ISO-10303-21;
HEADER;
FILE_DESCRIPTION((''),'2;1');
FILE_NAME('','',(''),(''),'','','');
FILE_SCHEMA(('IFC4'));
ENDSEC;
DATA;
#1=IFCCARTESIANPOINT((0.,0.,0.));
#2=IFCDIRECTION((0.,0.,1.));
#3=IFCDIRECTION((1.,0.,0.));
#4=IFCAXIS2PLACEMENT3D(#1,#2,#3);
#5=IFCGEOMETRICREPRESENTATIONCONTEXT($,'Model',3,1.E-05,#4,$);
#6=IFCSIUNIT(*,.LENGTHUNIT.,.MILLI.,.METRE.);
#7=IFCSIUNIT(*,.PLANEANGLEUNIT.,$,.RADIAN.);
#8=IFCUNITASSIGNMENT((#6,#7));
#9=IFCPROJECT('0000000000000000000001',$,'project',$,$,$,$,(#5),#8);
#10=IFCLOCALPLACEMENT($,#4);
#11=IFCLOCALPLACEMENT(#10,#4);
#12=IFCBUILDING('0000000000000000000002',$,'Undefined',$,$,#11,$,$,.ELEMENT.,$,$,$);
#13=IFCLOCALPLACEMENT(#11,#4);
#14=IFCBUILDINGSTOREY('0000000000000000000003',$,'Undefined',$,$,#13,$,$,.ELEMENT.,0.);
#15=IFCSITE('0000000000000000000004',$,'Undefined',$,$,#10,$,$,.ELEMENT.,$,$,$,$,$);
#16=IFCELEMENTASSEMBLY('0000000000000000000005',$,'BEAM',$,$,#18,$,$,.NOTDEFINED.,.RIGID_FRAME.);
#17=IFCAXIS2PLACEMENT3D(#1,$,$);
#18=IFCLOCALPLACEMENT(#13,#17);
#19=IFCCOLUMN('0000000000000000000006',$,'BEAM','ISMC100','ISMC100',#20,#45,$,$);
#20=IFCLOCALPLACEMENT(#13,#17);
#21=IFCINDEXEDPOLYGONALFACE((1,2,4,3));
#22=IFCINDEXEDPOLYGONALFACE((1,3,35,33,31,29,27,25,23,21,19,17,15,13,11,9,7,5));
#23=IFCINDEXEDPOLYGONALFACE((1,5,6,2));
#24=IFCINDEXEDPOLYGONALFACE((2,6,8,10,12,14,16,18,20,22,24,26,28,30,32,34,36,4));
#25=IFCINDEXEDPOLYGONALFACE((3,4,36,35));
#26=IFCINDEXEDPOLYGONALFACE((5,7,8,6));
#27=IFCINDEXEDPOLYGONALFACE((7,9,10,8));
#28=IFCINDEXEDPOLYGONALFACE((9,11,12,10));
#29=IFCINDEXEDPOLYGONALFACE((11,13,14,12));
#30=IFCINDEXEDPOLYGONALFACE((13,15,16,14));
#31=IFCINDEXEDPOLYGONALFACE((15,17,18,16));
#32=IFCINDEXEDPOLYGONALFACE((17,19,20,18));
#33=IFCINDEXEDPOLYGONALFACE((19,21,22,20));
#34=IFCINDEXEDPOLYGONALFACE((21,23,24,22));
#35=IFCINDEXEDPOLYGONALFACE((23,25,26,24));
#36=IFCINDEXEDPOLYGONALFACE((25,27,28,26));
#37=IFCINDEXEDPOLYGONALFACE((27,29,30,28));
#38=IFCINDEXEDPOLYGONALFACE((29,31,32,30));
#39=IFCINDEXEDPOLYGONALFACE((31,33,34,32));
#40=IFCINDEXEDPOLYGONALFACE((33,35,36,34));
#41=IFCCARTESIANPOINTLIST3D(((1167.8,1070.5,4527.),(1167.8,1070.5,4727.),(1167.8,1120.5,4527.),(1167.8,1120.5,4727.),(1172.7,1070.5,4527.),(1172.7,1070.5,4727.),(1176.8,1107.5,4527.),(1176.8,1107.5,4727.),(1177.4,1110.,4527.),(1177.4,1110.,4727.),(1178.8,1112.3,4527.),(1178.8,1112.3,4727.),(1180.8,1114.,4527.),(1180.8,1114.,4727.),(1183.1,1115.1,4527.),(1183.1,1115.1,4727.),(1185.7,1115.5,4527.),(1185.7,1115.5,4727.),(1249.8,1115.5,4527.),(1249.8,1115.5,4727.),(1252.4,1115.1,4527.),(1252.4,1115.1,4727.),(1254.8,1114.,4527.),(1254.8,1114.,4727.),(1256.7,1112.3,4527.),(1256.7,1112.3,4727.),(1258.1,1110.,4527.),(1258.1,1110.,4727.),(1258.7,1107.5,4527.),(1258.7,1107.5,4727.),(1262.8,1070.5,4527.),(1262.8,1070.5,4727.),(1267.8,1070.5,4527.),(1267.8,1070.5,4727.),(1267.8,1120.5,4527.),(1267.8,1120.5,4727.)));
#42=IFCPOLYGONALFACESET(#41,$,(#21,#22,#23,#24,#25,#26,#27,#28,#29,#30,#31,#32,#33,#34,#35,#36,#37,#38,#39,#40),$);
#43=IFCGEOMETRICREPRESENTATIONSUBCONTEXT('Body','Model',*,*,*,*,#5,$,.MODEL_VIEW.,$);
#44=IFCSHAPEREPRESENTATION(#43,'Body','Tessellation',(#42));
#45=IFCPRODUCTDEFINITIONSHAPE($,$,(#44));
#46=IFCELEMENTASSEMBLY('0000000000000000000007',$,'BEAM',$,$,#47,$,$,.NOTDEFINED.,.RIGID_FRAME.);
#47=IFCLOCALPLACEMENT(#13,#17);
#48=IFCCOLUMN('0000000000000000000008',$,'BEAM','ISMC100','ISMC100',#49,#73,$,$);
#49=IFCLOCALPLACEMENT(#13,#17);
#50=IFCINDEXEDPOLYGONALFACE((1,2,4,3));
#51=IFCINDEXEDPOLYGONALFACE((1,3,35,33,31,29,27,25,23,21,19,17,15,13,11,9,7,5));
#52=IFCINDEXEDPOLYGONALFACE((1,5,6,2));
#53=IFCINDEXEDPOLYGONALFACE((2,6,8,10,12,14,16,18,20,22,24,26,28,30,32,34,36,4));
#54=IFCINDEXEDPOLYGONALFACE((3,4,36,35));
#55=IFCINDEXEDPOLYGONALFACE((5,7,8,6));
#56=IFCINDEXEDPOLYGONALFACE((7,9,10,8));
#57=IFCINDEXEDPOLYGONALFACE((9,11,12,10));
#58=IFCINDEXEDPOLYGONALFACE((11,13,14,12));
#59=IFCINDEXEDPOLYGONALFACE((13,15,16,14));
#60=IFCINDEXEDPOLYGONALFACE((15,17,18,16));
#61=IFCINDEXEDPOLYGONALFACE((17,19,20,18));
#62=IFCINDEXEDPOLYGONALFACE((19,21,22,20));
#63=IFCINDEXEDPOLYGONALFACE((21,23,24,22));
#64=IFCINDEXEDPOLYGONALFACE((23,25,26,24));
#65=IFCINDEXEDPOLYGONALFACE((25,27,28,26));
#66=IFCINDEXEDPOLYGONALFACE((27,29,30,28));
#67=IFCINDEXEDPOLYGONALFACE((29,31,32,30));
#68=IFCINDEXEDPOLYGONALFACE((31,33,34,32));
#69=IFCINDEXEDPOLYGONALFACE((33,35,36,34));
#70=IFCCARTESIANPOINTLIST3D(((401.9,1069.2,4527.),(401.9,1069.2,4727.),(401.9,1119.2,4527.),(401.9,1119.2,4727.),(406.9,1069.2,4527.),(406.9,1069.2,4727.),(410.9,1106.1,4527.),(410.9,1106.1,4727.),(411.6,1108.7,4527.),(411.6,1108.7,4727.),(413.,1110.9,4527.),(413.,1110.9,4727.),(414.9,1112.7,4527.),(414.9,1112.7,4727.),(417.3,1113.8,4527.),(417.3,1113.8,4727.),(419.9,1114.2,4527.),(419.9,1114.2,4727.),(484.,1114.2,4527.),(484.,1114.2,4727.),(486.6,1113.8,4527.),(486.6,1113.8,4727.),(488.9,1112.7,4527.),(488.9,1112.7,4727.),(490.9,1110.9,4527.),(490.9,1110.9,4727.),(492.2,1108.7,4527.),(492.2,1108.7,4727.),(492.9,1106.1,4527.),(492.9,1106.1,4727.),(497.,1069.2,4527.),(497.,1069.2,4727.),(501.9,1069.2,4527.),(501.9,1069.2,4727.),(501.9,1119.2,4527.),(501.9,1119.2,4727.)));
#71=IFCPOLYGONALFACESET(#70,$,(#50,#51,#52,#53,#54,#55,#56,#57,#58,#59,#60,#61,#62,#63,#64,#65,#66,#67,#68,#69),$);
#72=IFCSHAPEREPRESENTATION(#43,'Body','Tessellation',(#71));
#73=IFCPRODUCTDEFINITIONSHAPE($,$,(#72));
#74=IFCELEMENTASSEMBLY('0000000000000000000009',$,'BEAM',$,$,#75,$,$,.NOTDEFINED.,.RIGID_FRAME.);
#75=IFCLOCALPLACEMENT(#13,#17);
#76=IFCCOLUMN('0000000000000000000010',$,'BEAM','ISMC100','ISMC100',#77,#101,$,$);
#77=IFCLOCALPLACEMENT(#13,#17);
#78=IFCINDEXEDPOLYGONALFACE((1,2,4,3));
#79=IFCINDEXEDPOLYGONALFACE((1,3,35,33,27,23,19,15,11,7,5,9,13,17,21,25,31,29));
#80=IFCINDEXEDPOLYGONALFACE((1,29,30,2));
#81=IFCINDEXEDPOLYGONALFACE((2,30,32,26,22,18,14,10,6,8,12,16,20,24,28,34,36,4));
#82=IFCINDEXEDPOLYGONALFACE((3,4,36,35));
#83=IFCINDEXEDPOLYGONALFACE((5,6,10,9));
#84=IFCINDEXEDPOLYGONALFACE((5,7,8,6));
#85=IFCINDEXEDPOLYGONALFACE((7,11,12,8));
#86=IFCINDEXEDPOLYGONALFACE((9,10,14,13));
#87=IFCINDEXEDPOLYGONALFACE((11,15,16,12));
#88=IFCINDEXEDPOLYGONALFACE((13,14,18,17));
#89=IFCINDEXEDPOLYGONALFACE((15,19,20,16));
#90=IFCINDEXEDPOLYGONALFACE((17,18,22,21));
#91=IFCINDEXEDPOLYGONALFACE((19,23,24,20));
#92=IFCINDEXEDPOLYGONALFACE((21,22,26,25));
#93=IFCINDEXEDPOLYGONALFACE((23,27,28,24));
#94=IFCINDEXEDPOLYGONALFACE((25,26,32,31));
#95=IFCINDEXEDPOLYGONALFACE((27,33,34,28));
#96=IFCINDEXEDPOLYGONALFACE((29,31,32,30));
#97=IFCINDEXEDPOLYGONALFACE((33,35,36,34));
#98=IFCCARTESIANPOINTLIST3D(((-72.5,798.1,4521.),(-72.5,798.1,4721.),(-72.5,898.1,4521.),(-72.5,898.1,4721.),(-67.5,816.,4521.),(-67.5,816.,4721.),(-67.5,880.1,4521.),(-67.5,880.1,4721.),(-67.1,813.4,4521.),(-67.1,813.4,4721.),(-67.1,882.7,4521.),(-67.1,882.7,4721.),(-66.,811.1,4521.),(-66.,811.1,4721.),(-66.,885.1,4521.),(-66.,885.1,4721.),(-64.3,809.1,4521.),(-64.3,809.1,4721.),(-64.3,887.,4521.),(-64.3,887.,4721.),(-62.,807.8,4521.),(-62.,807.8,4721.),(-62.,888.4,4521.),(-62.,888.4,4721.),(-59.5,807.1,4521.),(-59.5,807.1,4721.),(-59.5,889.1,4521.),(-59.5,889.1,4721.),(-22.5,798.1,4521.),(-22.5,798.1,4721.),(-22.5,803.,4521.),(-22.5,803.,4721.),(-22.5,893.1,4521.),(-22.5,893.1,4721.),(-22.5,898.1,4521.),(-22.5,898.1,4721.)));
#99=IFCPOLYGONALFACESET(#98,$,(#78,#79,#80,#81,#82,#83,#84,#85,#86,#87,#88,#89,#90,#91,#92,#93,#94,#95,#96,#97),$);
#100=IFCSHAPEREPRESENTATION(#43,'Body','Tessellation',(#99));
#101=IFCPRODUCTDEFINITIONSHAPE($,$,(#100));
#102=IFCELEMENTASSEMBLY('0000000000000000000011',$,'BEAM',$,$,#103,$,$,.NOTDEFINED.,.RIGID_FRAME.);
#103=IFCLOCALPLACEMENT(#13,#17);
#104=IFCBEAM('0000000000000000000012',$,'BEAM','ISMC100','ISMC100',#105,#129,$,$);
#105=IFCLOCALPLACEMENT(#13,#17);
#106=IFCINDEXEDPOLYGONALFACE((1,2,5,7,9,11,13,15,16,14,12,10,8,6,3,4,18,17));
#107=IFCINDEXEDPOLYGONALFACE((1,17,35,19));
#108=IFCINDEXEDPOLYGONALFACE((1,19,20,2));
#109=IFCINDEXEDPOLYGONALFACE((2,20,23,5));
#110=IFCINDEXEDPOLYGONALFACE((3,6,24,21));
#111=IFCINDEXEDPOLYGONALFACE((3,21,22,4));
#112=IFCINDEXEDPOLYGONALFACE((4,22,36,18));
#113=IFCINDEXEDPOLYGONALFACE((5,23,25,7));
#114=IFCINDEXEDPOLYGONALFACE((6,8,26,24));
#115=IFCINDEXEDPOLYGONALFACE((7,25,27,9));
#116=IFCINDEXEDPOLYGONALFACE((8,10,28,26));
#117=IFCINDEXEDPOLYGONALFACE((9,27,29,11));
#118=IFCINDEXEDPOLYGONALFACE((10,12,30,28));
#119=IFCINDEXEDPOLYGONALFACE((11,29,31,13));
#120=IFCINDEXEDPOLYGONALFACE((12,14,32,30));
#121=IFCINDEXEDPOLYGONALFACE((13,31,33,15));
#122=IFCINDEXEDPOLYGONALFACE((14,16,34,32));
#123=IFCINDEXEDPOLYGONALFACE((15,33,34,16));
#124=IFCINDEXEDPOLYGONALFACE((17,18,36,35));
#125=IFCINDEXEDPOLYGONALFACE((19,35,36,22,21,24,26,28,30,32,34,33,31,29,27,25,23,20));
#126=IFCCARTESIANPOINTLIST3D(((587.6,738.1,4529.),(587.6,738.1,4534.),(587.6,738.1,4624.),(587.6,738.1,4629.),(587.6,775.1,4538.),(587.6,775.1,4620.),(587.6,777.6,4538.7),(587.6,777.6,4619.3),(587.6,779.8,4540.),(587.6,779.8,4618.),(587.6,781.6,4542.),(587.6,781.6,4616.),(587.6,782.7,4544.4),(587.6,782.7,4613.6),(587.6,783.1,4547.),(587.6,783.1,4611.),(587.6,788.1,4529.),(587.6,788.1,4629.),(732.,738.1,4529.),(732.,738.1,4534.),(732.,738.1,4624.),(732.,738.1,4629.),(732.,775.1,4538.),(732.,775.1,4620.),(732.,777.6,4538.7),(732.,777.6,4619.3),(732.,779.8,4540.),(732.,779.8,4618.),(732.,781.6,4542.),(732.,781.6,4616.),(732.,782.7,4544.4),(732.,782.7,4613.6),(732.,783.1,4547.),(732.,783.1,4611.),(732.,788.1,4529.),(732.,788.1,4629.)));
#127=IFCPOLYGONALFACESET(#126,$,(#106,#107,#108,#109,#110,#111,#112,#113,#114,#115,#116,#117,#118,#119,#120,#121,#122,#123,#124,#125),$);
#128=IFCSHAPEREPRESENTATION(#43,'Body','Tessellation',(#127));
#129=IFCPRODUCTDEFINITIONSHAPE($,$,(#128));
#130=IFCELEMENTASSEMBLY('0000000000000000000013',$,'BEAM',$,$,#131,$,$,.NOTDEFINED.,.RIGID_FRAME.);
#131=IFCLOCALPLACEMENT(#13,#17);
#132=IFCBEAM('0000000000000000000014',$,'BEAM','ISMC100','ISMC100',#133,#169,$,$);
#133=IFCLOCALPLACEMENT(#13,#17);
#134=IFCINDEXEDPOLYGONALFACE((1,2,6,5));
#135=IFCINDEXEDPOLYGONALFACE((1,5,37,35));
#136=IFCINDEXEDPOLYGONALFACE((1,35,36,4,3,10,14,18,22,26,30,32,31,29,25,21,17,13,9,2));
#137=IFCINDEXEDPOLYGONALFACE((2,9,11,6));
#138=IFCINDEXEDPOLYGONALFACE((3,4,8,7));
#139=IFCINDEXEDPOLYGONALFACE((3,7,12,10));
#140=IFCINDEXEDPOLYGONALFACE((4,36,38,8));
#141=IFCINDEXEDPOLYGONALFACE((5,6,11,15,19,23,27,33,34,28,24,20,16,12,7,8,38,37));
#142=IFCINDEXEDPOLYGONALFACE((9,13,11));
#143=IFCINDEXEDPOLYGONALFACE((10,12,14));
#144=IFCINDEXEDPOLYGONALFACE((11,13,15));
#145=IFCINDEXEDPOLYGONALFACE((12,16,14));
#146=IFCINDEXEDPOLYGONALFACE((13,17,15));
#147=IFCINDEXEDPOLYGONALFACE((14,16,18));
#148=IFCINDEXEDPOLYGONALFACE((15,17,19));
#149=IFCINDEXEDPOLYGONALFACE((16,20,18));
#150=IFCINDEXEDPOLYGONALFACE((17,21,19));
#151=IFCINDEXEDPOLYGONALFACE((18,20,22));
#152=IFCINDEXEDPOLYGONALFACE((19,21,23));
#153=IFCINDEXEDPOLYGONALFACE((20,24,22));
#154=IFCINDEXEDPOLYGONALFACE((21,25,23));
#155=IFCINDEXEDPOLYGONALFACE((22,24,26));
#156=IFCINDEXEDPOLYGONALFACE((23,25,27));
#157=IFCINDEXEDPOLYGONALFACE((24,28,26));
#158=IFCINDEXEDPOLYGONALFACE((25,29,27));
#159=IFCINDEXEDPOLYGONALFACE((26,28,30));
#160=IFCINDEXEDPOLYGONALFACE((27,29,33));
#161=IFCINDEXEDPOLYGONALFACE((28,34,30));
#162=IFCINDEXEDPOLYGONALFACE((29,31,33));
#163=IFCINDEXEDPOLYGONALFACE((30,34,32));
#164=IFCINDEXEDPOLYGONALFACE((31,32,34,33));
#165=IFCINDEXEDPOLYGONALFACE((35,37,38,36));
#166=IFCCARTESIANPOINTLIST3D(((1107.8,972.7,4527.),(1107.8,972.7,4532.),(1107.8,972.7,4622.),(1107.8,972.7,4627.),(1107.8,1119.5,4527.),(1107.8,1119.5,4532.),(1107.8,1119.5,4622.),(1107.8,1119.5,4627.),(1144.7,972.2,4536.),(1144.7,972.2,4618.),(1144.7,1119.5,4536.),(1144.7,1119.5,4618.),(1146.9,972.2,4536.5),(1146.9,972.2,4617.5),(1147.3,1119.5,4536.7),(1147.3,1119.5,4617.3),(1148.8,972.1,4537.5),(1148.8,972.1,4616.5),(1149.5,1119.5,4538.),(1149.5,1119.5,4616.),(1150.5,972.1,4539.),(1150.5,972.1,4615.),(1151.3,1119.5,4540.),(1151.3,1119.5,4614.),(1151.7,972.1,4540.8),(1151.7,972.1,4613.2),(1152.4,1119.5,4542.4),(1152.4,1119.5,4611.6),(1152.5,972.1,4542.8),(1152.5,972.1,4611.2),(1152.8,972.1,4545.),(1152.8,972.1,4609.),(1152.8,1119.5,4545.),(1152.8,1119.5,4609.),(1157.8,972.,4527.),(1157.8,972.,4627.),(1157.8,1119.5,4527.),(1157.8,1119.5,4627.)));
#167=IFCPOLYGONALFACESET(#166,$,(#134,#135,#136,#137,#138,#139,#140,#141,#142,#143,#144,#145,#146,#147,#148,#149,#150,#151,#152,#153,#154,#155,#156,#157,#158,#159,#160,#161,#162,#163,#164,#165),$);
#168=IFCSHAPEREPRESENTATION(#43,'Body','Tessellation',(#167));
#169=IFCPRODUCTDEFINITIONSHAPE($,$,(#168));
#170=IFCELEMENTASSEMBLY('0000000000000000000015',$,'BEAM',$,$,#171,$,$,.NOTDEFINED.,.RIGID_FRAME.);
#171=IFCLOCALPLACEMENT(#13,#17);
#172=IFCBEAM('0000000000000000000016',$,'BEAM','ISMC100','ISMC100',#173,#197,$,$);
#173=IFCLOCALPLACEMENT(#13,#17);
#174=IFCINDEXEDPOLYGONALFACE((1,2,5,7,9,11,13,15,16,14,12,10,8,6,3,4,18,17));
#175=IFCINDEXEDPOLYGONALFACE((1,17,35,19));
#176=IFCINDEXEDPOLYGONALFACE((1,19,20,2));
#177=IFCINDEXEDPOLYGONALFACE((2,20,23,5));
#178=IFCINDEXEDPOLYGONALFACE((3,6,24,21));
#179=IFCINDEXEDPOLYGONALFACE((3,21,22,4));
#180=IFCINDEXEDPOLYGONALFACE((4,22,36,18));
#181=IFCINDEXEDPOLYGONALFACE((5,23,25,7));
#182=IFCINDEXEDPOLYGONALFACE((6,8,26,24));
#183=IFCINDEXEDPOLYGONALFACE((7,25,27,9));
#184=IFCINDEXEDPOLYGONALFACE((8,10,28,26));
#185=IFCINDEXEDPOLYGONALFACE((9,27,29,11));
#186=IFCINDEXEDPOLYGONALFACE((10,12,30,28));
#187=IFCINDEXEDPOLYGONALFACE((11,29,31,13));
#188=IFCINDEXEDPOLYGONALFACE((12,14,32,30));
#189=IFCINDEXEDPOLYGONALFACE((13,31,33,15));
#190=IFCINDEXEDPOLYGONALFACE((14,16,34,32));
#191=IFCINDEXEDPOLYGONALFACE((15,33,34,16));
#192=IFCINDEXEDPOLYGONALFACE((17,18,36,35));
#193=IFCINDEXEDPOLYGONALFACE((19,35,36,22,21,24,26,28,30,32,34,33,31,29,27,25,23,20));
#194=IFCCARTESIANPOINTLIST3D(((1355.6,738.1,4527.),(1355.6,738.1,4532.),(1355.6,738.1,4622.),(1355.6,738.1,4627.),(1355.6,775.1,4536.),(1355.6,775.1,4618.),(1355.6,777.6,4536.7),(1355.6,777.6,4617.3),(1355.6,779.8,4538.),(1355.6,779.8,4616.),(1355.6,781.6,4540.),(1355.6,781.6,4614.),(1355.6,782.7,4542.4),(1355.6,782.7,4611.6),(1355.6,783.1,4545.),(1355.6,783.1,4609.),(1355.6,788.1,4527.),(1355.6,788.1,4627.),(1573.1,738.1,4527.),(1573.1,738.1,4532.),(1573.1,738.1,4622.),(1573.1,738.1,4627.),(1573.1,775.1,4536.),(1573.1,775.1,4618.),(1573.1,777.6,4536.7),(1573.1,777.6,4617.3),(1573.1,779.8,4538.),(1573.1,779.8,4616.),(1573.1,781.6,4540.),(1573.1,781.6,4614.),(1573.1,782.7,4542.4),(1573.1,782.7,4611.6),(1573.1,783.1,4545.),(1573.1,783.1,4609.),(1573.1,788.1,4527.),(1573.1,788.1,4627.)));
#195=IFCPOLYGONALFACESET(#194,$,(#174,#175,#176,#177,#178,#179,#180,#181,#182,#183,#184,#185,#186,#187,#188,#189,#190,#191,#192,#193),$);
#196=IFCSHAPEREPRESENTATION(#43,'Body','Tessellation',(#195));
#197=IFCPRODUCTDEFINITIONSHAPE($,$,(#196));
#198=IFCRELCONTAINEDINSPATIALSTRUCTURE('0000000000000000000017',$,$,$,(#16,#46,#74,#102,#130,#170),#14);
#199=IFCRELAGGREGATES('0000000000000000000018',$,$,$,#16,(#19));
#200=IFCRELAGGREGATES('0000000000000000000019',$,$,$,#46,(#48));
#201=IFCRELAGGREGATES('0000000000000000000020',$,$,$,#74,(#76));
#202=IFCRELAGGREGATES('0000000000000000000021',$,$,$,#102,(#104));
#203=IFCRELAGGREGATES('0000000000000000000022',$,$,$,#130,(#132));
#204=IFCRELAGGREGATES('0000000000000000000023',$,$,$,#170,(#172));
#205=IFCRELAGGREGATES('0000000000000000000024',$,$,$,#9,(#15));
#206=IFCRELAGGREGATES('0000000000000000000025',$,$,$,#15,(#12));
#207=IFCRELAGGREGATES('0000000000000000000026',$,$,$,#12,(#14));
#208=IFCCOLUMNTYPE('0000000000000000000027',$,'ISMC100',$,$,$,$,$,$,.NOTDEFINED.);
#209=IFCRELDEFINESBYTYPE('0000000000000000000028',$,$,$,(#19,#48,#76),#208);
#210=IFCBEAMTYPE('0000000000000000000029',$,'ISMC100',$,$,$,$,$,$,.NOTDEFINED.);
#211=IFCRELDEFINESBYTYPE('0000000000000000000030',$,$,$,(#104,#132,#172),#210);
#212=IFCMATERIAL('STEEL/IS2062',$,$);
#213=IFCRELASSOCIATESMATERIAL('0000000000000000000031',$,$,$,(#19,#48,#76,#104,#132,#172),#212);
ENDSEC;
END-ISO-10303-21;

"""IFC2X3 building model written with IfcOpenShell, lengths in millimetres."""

from ifc_helpers import new_model, si_unit, frame, origin_with_axes, origin_2d_with_axis, place, context, subcontext, project, spatial, u_section, extrude, clip, halfspace, material, type_object, element, aggregate, save


model = new_model("IFC2X3")

# Units and contexts
model_context = context("Model", 3, precision=1e-05, world=origin_with_axes())
body_context = subcontext(model_context, "Body", "Model", "MODEL_VIEW")
ifc_project = project(units=[si_unit("LENGTHUNIT", "METRE", prefix="MILLI"), si_unit("PLANEANGLEUNIT", "RADIAN")], contexts=[model_context])

# Site, building, storey
site_placement = place(None, origin_with_axes())
site = spatial("IfcSite", under=ifc_project, at=site_placement, Name="Undefined", CompositionType="ELEMENT")
building_placement = place(site_placement, origin_with_axes())
building = spatial("IfcBuilding", under=site, at=building_placement, Name="Undefined", CompositionType="ELEMENT")
storey_placement = place(building_placement, origin_with_axes())
storey = spatial("IfcBuildingStorey", under=building, at=storey_placement, Name="Undefined", CompositionType="ELEMENT", Elevation=0.0)

# Element assemblies, columns
assembly_1_placement = place(storey_placement, origin_with_axes())
assembly_1 = element("IfcElementAssembly", 1, at=assembly_1_placement, inside=storey, Name="BEAM", AssemblyPlace="NOTDEFINED", PredefinedType="RIGID_FRAME")
ifc_material = material(Name="STEEL/IS2062")
column_type = type_object("IfcColumnType", Name="ISMC100", PredefinedType="NOTDEFINED")
column_1_placement = place(assembly_1_placement, frame((1217.8, 1095.5, 4527.0), z_axis=(0.0, 0.0, 1.0), x_axis=(-1.0, 0.0, 0.0)))
column_1 = element("IfcColumn", 2, at=column_1_placement, type_object=column_type, material=ifc_material, Name="BEAM", Description="ISMC100", ObjectType="ISMC100", context=body_context, shape_type="SweptSolid", body=[
    extrude(u_section(Depth=100.0, FlangeWidth=50.0, WebThickness=5.0, FlangeThickness=7.7, FilletRadius=9.0, FlangeSlope=0.10956, at=origin_2d_with_axis()), frame((0.0, 0.0, 200.0), z_axis=(0.0, 0.0, -1.0), x_axis=(0.0, 1.0, 0.0)), (0.0, 0.0, 1.0), 200.0),
])
aggregate(assembly_1, [column_1])
assembly_2_placement = place(storey_placement, origin_with_axes())
assembly_2 = element("IfcElementAssembly", 3, at=assembly_2_placement, inside=storey, Name="BEAM", AssemblyPlace="NOTDEFINED", PredefinedType="RIGID_FRAME")
column_2_placement = place(assembly_2_placement, frame((451.9, 1094.2, 4527.0), z_axis=(0.0, 0.0, 1.0), x_axis=(-1.0, 0.0, 0.0)))
column_2 = element("IfcColumn", 4, at=column_2_placement, type_object=column_type, material=ifc_material, Name="BEAM", Description="ISMC100", ObjectType="ISMC100", context=body_context, shape_type="SweptSolid", body=[
    extrude(u_section(Depth=100.0, FlangeWidth=50.0, WebThickness=5.0, FlangeThickness=7.7, FilletRadius=9.0, FlangeSlope=0.10956, at=origin_2d_with_axis()), frame((0.0, 0.0, 200.0), z_axis=(0.0, 0.0, -1.0), x_axis=(0.0, 1.0, 0.0)), (0.0, 0.0, 1.0), 200.0),
])
aggregate(assembly_2, [column_2])
assembly_3_placement = place(storey_placement, origin_with_axes())
assembly_3 = element("IfcElementAssembly", 5, at=assembly_3_placement, inside=storey, Name="BEAM", AssemblyPlace="NOTDEFINED", PredefinedType="RIGID_FRAME")
column_3_placement = place(assembly_3_placement, frame((-47.5, 848.1, 4521.0), z_axis=(0.0, 0.0, 1.0), x_axis=(0.0, -1.0, 0.0)))
column_3 = element("IfcColumn", 6, at=column_3_placement, type_object=column_type, material=ifc_material, Name="BEAM", Description="ISMC100", ObjectType="ISMC100", context=body_context, shape_type="SweptSolid", body=[
    extrude(u_section(Depth=100.0, FlangeWidth=50.0, WebThickness=5.0, FlangeThickness=7.7, FilletRadius=9.0, FlangeSlope=0.10956, at=origin_2d_with_axis()), frame((0.0, 0.0, 200.0), z_axis=(0.0, 0.0, -1.0), x_axis=(0.0, 1.0, 0.0)), (0.0, 0.0, 1.0), 200.0),
])
aggregate(assembly_3, [column_3])

# Element assemblies, beams
assembly_4_placement = place(storey_placement, origin_with_axes())
assembly_4 = element("IfcElementAssembly", 7, at=assembly_4_placement, inside=storey, Name="BEAM", AssemblyPlace="NOTDEFINED", PredefinedType="RIGID_FRAME")
beam_type_1 = type_object("IfcBeamType", Name="ISMC100", PredefinedType="NOTDEFINED")
beam_1_placement = place(assembly_4_placement, frame((732.0, 763.1, 4579.0), z_axis=(0.0, 0.0, -1.0), x_axis=(-1.0, 0.0, 0.0)))
beam_1 = element("IfcBeam", 8, at=beam_1_placement, type_object=beam_type_1, material=ifc_material, Name="BEAM", Description="ISMC100", ObjectType="ISMC100", context=body_context, shape_type="SweptSolid", body=[
    extrude(u_section(Depth=100.0, FlangeWidth=50.0, WebThickness=5.0, FlangeThickness=7.7, FilletRadius=9.0, FlangeSlope=0.10956, at=origin_2d_with_axis()), frame((144.4, 0.0, 0.0), z_axis=(-1.0, 0.0, 0.0), x_axis=(0.0, -1.0, 0.0)), (0.0, 0.0, 1.0), 144.4),
])
aggregate(assembly_4, [beam_1])
assembly_5_placement = place(storey_placement, origin_with_axes())
assembly_5 = element("IfcElementAssembly", 9, at=assembly_5_placement, inside=storey, Name="BEAM", AssemblyPlace="NOTDEFINED", PredefinedType="RIGID_FRAME")
beam_2_placement = place(assembly_5_placement, frame((1132.8, 972.0, 4577.0), z_axis=(0.0, 0.0, -1.0), x_axis=(0.0, 1.0, 0.0)))
beam_2 = element("IfcBeam", 10, at=beam_2_placement, type_object=beam_type_1, material=ifc_material, Name="BEAM", Description="ISMC100", ObjectType="ISMC100", context=body_context, shape_type="Clipping", body=[
    clip(extrude(u_section(Depth=100.0, FlangeWidth=50.0, WebThickness=5.0, FlangeThickness=7.7, FilletRadius=9.0, FlangeSlope=0.10956, at=origin_2d_with_axis()), frame((147.5, 0.0, 0.0), z_axis=(-1.0, 0.0, 0.0), x_axis=(0.0, -1.0, 0.0)), (0.0, 0.0, 1.0), 147.5), halfspace(frame((0.0, 25.0, -50.0), z_axis=(-0.999902, -0.013997, 0.0), x_axis=(0.0, 0.0, 1.0)), False)),
])
aggregate(assembly_5, [beam_2])
assembly_6_placement = place(storey_placement, origin_with_axes())
assembly_6 = element("IfcElementAssembly", 11, at=assembly_6_placement, inside=storey, Name="BEAM", AssemblyPlace="NOTDEFINED", PredefinedType="RIGID_FRAME")
beam_3_placement = place(assembly_6_placement, frame((1573.1, 763.1, 4577.0), z_axis=(0.0, 0.0, -1.0), x_axis=(-1.0, 0.0, 0.0)))
beam_3 = element("IfcBeam", 12, at=beam_3_placement, type_object=beam_type_1, material=ifc_material, Name="BEAM", Description="ISMC100", ObjectType="ISMC100", context=body_context, shape_type="SweptSolid", body=[
    extrude(u_section(Depth=100.0, FlangeWidth=50.0, WebThickness=5.0, FlangeThickness=7.7, FilletRadius=9.0, FlangeSlope=0.10956, at=origin_2d_with_axis()), frame((217.6, 0.0, 0.0), z_axis=(-1.0, 0.0, 0.0), x_axis=(0.0, -1.0, 0.0)), (0.0, 0.0, 1.0), 217.6),
])
aggregate(assembly_6, [beam_3])

save(model, "model.ifc")
